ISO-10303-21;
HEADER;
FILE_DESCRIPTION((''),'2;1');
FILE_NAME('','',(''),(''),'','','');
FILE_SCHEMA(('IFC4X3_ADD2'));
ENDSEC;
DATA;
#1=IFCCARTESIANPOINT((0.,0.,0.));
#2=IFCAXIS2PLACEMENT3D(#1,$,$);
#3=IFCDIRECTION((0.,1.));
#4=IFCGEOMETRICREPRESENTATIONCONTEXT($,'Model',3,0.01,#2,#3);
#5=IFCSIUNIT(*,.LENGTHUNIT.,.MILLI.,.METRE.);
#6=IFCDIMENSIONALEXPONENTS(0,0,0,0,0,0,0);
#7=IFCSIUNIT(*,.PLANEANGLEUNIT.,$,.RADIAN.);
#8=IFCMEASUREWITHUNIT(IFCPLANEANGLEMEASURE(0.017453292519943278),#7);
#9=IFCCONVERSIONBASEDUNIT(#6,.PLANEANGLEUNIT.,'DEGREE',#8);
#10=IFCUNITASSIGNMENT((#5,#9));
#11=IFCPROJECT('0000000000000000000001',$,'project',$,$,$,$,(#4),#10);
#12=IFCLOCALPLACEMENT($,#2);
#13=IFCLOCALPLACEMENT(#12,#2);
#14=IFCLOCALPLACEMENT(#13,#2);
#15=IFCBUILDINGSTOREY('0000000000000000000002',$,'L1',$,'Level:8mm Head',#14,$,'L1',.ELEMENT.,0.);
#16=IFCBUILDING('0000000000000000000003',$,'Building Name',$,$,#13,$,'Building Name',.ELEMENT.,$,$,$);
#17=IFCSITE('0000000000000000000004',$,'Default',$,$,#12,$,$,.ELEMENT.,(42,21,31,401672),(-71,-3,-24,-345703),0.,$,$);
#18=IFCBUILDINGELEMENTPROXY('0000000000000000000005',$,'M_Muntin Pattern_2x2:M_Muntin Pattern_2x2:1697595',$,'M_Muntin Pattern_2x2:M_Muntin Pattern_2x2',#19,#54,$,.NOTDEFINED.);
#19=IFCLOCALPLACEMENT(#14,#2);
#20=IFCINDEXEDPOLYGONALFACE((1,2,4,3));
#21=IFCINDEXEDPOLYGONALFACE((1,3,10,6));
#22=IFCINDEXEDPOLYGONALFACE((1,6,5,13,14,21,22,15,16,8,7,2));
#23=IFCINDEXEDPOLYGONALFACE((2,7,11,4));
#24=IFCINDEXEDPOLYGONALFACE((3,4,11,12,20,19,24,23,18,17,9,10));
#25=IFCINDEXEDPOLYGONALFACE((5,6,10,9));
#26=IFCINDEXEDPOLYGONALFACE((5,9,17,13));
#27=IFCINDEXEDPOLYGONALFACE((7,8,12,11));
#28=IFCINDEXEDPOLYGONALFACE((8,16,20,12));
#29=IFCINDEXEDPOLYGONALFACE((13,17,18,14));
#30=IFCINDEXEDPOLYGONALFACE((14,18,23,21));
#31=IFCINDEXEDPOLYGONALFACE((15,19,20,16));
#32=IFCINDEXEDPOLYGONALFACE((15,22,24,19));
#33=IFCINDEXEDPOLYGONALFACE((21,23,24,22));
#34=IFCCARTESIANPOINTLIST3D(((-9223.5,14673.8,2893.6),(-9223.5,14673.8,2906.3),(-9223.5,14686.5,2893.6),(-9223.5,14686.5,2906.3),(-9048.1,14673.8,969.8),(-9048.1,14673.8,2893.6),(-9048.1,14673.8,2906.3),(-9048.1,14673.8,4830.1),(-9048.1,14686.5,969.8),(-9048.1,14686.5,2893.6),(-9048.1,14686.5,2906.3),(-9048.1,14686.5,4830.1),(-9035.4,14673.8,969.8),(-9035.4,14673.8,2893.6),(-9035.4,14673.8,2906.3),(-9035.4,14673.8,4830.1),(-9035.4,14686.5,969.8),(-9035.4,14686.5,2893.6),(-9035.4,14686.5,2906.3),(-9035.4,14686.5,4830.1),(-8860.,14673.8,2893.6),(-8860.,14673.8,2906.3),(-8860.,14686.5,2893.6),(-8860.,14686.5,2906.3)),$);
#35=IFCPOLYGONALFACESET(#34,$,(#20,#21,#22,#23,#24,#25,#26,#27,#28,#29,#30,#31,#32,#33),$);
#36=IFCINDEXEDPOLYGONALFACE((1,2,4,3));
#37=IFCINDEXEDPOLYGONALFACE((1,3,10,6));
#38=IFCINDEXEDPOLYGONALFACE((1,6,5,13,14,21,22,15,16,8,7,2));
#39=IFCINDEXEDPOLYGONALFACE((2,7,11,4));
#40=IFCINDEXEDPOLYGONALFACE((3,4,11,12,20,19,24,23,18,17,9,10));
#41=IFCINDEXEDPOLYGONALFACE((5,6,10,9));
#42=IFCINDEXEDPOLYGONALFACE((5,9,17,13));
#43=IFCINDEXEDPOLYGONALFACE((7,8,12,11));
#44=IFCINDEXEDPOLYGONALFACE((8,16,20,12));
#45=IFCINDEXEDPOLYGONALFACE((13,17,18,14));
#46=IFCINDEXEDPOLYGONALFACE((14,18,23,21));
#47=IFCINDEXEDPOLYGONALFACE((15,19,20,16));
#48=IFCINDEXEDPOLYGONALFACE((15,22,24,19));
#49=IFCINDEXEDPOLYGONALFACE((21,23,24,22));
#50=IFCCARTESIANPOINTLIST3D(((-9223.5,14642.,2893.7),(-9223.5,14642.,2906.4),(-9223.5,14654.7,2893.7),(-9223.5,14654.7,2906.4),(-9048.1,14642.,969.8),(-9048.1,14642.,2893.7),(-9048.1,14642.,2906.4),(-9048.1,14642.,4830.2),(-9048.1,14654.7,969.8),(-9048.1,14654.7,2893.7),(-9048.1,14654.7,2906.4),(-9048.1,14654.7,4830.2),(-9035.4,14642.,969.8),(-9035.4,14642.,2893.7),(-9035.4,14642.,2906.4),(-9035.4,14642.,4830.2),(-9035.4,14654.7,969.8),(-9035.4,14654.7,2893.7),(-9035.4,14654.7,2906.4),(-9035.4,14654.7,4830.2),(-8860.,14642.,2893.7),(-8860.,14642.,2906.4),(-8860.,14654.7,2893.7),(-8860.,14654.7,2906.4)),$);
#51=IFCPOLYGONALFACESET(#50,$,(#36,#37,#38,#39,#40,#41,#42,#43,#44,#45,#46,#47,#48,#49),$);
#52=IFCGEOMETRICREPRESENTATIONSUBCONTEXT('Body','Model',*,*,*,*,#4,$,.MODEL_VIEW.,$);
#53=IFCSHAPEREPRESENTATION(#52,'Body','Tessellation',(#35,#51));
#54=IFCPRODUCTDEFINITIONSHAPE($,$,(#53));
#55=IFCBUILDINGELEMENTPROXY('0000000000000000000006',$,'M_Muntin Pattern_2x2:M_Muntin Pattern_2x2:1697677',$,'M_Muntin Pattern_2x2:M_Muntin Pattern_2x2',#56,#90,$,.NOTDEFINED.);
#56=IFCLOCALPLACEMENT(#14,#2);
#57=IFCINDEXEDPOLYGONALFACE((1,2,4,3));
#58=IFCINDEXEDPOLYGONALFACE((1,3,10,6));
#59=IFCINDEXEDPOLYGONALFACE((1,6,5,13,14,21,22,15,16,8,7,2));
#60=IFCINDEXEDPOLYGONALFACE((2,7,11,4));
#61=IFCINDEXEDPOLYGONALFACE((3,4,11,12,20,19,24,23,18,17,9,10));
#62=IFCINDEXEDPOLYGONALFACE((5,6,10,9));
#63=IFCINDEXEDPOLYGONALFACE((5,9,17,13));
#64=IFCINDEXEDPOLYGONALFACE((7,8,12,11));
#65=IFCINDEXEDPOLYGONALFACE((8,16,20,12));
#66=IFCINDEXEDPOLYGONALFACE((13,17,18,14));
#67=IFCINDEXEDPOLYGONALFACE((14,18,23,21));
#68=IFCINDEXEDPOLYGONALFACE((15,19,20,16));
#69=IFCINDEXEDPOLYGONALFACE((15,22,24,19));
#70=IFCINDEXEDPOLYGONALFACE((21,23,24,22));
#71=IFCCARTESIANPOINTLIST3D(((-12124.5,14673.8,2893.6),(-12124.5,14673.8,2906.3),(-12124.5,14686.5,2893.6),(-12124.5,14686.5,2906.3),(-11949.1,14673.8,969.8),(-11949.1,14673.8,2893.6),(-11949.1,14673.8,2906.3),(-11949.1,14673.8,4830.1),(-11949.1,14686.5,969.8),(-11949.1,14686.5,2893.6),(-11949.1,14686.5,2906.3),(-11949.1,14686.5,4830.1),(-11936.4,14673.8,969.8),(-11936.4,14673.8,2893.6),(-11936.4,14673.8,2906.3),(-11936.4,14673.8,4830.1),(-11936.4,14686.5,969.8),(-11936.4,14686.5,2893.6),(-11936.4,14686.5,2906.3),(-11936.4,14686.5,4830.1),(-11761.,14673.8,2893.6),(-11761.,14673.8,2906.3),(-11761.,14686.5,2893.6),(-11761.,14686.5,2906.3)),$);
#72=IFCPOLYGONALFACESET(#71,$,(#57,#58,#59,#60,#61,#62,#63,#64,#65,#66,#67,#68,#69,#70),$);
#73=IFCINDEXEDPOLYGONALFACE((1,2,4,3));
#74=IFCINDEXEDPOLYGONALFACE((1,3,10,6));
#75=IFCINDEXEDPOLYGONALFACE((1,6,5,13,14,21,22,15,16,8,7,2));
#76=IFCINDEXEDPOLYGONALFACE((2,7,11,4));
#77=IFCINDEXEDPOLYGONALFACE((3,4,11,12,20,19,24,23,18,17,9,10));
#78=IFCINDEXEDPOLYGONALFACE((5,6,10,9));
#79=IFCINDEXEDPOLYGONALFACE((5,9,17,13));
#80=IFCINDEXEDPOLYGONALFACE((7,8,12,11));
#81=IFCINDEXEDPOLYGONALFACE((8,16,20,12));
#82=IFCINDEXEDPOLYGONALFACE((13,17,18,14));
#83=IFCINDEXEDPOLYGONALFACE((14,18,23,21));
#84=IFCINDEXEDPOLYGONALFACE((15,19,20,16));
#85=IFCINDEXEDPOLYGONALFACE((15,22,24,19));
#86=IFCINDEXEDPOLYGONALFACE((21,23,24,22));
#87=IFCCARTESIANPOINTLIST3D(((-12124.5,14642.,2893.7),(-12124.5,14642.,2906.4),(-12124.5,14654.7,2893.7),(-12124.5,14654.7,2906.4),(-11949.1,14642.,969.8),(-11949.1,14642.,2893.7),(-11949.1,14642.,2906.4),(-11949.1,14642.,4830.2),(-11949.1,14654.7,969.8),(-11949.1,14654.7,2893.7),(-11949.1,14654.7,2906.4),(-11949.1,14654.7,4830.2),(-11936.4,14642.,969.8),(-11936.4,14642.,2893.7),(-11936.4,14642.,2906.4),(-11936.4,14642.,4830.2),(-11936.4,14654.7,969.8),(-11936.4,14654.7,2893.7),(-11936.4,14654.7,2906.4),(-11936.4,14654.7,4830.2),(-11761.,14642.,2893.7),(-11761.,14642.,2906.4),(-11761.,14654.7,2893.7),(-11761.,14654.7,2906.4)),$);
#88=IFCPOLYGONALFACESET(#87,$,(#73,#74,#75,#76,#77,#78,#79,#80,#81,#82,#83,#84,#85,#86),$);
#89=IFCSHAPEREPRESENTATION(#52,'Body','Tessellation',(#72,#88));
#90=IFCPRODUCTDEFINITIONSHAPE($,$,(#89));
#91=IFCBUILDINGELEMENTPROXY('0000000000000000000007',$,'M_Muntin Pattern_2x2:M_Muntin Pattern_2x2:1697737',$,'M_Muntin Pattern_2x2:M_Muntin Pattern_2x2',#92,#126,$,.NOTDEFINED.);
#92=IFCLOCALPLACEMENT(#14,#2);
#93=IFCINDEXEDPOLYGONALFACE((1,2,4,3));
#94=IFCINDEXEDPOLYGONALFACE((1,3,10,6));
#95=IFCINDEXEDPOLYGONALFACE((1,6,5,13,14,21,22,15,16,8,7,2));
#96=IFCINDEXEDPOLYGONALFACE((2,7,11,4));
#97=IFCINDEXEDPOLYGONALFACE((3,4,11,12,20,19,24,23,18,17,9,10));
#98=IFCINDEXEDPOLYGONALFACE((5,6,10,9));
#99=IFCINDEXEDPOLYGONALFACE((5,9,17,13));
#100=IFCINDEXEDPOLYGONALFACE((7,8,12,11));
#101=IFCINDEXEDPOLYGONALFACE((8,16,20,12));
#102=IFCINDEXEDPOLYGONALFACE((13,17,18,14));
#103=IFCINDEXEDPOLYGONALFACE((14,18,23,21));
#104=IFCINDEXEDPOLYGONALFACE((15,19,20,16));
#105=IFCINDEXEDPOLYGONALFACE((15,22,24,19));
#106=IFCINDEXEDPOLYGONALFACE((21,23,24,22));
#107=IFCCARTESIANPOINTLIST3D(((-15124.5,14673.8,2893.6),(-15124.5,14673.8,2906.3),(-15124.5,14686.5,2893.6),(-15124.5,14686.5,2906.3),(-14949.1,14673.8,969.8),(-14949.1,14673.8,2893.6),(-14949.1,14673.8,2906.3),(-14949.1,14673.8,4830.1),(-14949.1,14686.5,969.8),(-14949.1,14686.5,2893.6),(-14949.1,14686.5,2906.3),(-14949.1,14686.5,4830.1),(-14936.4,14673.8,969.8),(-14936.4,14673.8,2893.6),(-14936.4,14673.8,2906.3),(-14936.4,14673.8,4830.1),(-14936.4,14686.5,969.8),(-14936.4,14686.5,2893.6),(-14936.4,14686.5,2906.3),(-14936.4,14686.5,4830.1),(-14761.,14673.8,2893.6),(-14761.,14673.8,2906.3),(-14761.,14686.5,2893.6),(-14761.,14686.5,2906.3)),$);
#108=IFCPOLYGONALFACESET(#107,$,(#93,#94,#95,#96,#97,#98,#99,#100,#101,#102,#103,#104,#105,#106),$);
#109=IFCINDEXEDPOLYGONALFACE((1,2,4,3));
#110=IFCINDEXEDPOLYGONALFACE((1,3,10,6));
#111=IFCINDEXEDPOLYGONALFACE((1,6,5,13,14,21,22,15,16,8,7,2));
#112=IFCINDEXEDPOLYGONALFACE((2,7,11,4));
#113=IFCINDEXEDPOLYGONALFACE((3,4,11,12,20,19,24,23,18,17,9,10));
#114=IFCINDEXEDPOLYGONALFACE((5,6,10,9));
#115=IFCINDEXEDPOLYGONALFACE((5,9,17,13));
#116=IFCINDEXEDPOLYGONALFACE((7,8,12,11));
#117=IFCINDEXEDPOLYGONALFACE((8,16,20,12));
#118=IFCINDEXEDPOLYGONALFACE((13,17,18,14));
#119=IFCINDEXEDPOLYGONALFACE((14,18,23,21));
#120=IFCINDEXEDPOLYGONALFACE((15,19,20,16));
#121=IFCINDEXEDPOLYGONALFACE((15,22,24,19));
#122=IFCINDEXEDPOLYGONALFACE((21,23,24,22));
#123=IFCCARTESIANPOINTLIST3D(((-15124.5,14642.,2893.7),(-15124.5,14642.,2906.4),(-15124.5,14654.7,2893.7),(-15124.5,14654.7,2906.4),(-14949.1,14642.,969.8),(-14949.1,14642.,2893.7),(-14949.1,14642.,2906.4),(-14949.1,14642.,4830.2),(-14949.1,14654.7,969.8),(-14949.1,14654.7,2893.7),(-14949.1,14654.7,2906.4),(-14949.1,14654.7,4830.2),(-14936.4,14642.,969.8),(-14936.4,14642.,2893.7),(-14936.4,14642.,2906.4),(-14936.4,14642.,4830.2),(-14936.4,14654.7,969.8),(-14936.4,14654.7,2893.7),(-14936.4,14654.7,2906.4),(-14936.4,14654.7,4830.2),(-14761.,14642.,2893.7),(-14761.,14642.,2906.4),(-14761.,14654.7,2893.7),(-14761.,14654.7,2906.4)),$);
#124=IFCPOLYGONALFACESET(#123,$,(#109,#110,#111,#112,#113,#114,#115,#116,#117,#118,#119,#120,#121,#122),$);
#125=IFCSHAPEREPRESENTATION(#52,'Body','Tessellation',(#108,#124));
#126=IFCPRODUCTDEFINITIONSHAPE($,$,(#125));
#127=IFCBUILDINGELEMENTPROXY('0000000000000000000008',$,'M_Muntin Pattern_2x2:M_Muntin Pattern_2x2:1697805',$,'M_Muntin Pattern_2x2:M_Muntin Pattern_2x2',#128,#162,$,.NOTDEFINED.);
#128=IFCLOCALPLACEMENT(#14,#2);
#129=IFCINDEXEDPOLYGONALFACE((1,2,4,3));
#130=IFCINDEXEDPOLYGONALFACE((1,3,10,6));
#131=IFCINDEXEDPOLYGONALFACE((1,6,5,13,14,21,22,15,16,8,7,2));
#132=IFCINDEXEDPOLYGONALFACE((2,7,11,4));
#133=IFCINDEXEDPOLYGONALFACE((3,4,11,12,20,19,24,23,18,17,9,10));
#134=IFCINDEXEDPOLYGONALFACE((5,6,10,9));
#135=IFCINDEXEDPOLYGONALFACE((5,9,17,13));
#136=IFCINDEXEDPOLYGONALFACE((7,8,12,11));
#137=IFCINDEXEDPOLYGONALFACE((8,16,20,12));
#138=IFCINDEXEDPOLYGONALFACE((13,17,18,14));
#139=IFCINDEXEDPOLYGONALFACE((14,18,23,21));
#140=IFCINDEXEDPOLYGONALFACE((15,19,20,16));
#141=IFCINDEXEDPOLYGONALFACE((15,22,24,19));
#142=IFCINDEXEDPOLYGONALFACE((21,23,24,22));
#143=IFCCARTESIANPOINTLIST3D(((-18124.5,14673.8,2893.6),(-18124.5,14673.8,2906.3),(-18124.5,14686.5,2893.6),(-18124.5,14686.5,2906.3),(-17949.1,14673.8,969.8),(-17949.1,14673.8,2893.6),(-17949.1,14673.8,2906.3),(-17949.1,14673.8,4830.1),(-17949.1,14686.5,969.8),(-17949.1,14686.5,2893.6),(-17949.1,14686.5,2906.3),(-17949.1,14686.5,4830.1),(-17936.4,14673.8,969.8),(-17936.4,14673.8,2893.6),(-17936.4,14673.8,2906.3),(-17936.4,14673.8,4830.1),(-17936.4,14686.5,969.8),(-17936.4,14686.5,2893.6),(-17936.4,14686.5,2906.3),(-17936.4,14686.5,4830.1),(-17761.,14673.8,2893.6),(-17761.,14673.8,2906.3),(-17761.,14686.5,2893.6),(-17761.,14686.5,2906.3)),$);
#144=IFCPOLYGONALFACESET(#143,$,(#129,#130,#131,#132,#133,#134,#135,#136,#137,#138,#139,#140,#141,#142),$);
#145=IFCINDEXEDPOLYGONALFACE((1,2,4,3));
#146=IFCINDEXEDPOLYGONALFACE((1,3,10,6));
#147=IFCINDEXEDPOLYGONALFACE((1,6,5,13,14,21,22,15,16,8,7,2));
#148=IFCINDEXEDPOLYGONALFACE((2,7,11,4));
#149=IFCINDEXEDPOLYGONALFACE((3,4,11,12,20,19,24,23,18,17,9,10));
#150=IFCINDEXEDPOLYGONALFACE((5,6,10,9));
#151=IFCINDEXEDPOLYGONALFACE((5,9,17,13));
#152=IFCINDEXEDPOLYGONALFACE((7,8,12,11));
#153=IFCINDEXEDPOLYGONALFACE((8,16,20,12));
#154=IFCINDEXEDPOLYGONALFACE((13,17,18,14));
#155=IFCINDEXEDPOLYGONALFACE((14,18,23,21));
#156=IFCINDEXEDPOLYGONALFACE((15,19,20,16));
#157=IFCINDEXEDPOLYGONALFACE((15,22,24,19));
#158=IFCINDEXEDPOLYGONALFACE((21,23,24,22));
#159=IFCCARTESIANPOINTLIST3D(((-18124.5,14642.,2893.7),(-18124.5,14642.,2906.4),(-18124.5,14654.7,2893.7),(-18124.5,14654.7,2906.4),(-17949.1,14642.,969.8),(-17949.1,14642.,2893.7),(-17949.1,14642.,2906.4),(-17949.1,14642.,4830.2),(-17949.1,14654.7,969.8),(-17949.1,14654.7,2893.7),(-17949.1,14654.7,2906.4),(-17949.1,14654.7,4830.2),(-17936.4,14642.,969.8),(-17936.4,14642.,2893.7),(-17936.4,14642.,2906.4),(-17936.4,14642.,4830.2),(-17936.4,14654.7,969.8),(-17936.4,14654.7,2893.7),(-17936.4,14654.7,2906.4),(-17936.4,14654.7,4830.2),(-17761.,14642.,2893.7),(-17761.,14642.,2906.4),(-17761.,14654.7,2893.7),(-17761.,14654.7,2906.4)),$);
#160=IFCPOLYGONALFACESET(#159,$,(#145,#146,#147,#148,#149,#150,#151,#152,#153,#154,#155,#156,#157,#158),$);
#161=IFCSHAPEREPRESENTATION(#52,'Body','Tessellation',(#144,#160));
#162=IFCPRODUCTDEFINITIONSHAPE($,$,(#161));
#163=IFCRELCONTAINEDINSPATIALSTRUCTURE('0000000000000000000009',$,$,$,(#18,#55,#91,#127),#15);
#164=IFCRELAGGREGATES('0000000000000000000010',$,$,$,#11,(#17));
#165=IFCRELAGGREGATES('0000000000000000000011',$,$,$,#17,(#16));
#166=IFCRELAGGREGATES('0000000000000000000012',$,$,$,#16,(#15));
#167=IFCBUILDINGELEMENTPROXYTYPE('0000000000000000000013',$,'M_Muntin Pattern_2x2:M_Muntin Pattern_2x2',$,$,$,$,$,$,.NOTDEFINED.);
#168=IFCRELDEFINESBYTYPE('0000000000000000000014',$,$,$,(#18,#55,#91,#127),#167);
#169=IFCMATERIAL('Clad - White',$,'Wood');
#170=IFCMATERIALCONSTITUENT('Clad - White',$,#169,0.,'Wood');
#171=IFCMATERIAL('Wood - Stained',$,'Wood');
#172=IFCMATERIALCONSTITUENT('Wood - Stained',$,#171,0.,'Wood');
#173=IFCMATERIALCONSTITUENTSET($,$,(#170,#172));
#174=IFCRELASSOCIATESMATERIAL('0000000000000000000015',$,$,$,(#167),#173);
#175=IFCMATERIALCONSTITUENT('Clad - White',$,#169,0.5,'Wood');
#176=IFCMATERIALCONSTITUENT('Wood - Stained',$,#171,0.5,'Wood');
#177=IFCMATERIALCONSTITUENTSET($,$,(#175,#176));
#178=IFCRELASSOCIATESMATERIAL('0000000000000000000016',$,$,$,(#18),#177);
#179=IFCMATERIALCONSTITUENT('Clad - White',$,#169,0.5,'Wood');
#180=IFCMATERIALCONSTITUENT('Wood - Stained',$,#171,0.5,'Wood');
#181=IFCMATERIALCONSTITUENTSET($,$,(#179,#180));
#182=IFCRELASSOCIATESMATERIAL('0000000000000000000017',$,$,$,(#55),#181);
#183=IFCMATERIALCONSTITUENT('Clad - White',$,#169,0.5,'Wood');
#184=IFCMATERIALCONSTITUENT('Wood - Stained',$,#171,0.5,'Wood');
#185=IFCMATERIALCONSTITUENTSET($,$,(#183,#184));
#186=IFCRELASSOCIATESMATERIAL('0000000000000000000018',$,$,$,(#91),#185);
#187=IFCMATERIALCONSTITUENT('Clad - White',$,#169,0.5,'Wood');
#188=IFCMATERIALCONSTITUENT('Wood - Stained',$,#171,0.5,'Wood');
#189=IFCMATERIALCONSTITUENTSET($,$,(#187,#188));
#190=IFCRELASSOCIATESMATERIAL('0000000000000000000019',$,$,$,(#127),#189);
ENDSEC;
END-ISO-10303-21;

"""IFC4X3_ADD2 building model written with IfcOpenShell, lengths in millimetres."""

from ifc_helpers import new_model, entity, si_unit, converted_unit, direction, frame, origin, place, context, subcontext, project, spatial, polyline, outline, extrude, source, transform, mapped, material, constituent, constituent_set, type_object, type_shapes, element, save


model = new_model("IFC4X3_ADD2")

# Units and contexts
model_context = context("Model", 3, precision=0.01, world=origin(), true_north=direction((0.0, 1.0)))
body_context = subcontext(model_context, "Body", "Model", "MODEL_VIEW")
ifc_project = project(units=[si_unit("LENGTHUNIT", "METRE", prefix="MILLI"), converted_unit("PLANEANGLEUNIT", "DEGREE", entity("IfcPlaneAngleMeasure", 0.017453292519943278), si_unit("PLANEANGLEUNIT", "RADIAN"), dimensions=[0, 0, 0, 0, 0, 0, 0])], contexts=[model_context])

# Site, building, storey
site_placement = place(None, origin())
site = spatial("IfcSite", under=ifc_project, at=site_placement, Name="Default", CompositionType="ELEMENT", RefLatitude=(42, 21, 31, 401672), RefLongitude=(-71, -3, -24, -345703), RefElevation=0.0)
building_placement = place(site_placement, origin())
building = spatial("IfcBuilding", under=site, at=building_placement, Name="Building Name", LongName="Building Name", CompositionType="ELEMENT")
storey_placement = place(building_placement, origin())
storey = spatial("IfcBuildingStorey", under=building, at=storey_placement, Name="L1", ObjectType="Level:8mm Head", LongName="L1", CompositionType="ELEMENT", Elevation=0.0)

# Building element proxies
ifc_material_1 = material(Name="Clad - White", Category="Wood")
ifc_constituent_1 = constituent(ifc_material_1, Name="Clad - White", Category="Wood", fraction=0.5)
ifc_material_2 = material(Name="Wood - Stained", Category="Wood")
ifc_constituent_2 = constituent(ifc_material_2, Name="Wood - Stained", Category="Wood", fraction=0.5)
ifc_constituent_set_1 = constituent_set(constituents=[ifc_constituent_1, ifc_constituent_2])
ifc_constituent_3 = constituent(ifc_material_1, Name="Clad - White", Category="Wood", fraction=0.0)
ifc_constituent_4 = constituent(ifc_material_2, Name="Wood - Stained", Category="Wood", fraction=0.0)
ifc_constituent_set_2 = constituent_set(constituents=[ifc_constituent_3, ifc_constituent_4])
building_element_proxy_type_1 = type_object("IfcBuildingElementProxyType", Name="M_Muntin Pattern_2x2:M_Muntin Pattern_2x2", PredefinedType="NOTDEFINED", material=ifc_constituent_set_2)
shared_shape_1 = source(origin(), body_context, "Body", "SweptSolid", [
    extrude(outline(polyline([(6.4, -6.4), (1930.1, -6.4), (1930.1, 6.3), (6.4, 6.3), (6.4, 181.7), (-6.3, 181.7), (-6.3, 6.3), (-1930.2, 6.3), (-1930.2, -6.4), (-6.3, -6.4), (-6.3, -181.7), (6.4, -181.7), (6.4, -6.4)])), frame((0.0, 9.5, 1930.1), z_axis=(0.0, 1.0, 0.0), x_axis=(0.0, 0.0, 1.0)), (0.0, 0.0, 1.0), 12.7),
    extrude(outline(polyline([(6.4, -6.4), (1930.2, -6.4), (1930.2, 6.3), (6.4, 6.3), (6.4, 181.7), (-6.3, 181.7), (-6.3, 6.3), (-1930.2, 6.3), (-1930.2, -6.4), (-6.3, -6.4), (-6.3, -181.7), (6.4, -181.7), (6.4, -6.4)])), frame((0.0, -22.2, 1930.2), z_axis=(0.0, 1.0, 0.0), x_axis=(0.0, 0.0, 1.0)), (0.0, 0.0, 1.0), 12.7),
])
type_shapes(building_element_proxy_type_1, [shared_shape_1])
proxy_1_placement = place(storey_placement, frame((-9041.8, 14664.3, 969.8)))
element("IfcBuildingElementProxy", 1, at=proxy_1_placement, inside=storey, type_object=building_element_proxy_type_1, material=ifc_constituent_set_1, Name="M_Muntin Pattern_2x2:M_Muntin Pattern_2x2:1697595", ObjectType="M_Muntin Pattern_2x2:M_Muntin Pattern_2x2", PredefinedType="NOTDEFINED", context=body_context, shape_type="MappedRepresentation", body=[
    mapped(shared_shape_1, transform((0.0, 0.0, 0.0), scale=1.0)),
])
ifc_constituent_5 = constituent(ifc_material_1, Name="Clad - White", Category="Wood", fraction=0.5)
ifc_constituent_6 = constituent(ifc_material_2, Name="Wood - Stained", Category="Wood", fraction=0.5)
ifc_constituent_set_3 = constituent_set(constituents=[ifc_constituent_5, ifc_constituent_6])
proxy_2_placement = place(storey_placement, frame((-11942.8, 14664.3, 969.8)))
element("IfcBuildingElementProxy", 2, at=proxy_2_placement, inside=storey, type_object=building_element_proxy_type_1, material=ifc_constituent_set_3, Name="M_Muntin Pattern_2x2:M_Muntin Pattern_2x2:1697677", ObjectType="M_Muntin Pattern_2x2:M_Muntin Pattern_2x2", PredefinedType="NOTDEFINED", context=body_context, shape_type="MappedRepresentation", body=[
    mapped(shared_shape_1, transform((0.0, 0.0, 0.0), scale=1.0)),
])
ifc_constituent_7 = constituent(ifc_material_1, Name="Clad - White", Category="Wood", fraction=0.5)
ifc_constituent_8 = constituent(ifc_material_2, Name="Wood - Stained", Category="Wood", fraction=0.5)
ifc_constituent_set_4 = constituent_set(constituents=[ifc_constituent_7, ifc_constituent_8])
proxy_3_placement = place(storey_placement, frame((-14942.8, 14664.3, 969.8)))
element("IfcBuildingElementProxy", 3, at=proxy_3_placement, inside=storey, type_object=building_element_proxy_type_1, material=ifc_constituent_set_4, Name="M_Muntin Pattern_2x2:M_Muntin Pattern_2x2:1697737", ObjectType="M_Muntin Pattern_2x2:M_Muntin Pattern_2x2", PredefinedType="NOTDEFINED", context=body_context, shape_type="MappedRepresentation", body=[
    mapped(shared_shape_1, transform((0.0, 0.0, 0.0), scale=1.0)),
])
ifc_constituent_9 = constituent(ifc_material_1, Name="Clad - White", Category="Wood", fraction=0.5)
ifc_constituent_10 = constituent(ifc_material_2, Name="Wood - Stained", Category="Wood", fraction=0.5)
ifc_constituent_set_5 = constituent_set(constituents=[ifc_constituent_9, ifc_constituent_10])
proxy_4_placement = place(storey_placement, frame((-17942.8, 14664.3, 969.8)))
element("IfcBuildingElementProxy", 4, at=proxy_4_placement, inside=storey, type_object=building_element_proxy_type_1, material=ifc_constituent_set_5, Name="M_Muntin Pattern_2x2:M_Muntin Pattern_2x2:1697805", ObjectType="M_Muntin Pattern_2x2:M_Muntin Pattern_2x2", PredefinedType="NOTDEFINED", context=body_context, shape_type="MappedRepresentation", body=[
    mapped(shared_shape_1, transform((0.0, 0.0, 0.0), scale=1.0)),
])

save(model, "model.ifc")
